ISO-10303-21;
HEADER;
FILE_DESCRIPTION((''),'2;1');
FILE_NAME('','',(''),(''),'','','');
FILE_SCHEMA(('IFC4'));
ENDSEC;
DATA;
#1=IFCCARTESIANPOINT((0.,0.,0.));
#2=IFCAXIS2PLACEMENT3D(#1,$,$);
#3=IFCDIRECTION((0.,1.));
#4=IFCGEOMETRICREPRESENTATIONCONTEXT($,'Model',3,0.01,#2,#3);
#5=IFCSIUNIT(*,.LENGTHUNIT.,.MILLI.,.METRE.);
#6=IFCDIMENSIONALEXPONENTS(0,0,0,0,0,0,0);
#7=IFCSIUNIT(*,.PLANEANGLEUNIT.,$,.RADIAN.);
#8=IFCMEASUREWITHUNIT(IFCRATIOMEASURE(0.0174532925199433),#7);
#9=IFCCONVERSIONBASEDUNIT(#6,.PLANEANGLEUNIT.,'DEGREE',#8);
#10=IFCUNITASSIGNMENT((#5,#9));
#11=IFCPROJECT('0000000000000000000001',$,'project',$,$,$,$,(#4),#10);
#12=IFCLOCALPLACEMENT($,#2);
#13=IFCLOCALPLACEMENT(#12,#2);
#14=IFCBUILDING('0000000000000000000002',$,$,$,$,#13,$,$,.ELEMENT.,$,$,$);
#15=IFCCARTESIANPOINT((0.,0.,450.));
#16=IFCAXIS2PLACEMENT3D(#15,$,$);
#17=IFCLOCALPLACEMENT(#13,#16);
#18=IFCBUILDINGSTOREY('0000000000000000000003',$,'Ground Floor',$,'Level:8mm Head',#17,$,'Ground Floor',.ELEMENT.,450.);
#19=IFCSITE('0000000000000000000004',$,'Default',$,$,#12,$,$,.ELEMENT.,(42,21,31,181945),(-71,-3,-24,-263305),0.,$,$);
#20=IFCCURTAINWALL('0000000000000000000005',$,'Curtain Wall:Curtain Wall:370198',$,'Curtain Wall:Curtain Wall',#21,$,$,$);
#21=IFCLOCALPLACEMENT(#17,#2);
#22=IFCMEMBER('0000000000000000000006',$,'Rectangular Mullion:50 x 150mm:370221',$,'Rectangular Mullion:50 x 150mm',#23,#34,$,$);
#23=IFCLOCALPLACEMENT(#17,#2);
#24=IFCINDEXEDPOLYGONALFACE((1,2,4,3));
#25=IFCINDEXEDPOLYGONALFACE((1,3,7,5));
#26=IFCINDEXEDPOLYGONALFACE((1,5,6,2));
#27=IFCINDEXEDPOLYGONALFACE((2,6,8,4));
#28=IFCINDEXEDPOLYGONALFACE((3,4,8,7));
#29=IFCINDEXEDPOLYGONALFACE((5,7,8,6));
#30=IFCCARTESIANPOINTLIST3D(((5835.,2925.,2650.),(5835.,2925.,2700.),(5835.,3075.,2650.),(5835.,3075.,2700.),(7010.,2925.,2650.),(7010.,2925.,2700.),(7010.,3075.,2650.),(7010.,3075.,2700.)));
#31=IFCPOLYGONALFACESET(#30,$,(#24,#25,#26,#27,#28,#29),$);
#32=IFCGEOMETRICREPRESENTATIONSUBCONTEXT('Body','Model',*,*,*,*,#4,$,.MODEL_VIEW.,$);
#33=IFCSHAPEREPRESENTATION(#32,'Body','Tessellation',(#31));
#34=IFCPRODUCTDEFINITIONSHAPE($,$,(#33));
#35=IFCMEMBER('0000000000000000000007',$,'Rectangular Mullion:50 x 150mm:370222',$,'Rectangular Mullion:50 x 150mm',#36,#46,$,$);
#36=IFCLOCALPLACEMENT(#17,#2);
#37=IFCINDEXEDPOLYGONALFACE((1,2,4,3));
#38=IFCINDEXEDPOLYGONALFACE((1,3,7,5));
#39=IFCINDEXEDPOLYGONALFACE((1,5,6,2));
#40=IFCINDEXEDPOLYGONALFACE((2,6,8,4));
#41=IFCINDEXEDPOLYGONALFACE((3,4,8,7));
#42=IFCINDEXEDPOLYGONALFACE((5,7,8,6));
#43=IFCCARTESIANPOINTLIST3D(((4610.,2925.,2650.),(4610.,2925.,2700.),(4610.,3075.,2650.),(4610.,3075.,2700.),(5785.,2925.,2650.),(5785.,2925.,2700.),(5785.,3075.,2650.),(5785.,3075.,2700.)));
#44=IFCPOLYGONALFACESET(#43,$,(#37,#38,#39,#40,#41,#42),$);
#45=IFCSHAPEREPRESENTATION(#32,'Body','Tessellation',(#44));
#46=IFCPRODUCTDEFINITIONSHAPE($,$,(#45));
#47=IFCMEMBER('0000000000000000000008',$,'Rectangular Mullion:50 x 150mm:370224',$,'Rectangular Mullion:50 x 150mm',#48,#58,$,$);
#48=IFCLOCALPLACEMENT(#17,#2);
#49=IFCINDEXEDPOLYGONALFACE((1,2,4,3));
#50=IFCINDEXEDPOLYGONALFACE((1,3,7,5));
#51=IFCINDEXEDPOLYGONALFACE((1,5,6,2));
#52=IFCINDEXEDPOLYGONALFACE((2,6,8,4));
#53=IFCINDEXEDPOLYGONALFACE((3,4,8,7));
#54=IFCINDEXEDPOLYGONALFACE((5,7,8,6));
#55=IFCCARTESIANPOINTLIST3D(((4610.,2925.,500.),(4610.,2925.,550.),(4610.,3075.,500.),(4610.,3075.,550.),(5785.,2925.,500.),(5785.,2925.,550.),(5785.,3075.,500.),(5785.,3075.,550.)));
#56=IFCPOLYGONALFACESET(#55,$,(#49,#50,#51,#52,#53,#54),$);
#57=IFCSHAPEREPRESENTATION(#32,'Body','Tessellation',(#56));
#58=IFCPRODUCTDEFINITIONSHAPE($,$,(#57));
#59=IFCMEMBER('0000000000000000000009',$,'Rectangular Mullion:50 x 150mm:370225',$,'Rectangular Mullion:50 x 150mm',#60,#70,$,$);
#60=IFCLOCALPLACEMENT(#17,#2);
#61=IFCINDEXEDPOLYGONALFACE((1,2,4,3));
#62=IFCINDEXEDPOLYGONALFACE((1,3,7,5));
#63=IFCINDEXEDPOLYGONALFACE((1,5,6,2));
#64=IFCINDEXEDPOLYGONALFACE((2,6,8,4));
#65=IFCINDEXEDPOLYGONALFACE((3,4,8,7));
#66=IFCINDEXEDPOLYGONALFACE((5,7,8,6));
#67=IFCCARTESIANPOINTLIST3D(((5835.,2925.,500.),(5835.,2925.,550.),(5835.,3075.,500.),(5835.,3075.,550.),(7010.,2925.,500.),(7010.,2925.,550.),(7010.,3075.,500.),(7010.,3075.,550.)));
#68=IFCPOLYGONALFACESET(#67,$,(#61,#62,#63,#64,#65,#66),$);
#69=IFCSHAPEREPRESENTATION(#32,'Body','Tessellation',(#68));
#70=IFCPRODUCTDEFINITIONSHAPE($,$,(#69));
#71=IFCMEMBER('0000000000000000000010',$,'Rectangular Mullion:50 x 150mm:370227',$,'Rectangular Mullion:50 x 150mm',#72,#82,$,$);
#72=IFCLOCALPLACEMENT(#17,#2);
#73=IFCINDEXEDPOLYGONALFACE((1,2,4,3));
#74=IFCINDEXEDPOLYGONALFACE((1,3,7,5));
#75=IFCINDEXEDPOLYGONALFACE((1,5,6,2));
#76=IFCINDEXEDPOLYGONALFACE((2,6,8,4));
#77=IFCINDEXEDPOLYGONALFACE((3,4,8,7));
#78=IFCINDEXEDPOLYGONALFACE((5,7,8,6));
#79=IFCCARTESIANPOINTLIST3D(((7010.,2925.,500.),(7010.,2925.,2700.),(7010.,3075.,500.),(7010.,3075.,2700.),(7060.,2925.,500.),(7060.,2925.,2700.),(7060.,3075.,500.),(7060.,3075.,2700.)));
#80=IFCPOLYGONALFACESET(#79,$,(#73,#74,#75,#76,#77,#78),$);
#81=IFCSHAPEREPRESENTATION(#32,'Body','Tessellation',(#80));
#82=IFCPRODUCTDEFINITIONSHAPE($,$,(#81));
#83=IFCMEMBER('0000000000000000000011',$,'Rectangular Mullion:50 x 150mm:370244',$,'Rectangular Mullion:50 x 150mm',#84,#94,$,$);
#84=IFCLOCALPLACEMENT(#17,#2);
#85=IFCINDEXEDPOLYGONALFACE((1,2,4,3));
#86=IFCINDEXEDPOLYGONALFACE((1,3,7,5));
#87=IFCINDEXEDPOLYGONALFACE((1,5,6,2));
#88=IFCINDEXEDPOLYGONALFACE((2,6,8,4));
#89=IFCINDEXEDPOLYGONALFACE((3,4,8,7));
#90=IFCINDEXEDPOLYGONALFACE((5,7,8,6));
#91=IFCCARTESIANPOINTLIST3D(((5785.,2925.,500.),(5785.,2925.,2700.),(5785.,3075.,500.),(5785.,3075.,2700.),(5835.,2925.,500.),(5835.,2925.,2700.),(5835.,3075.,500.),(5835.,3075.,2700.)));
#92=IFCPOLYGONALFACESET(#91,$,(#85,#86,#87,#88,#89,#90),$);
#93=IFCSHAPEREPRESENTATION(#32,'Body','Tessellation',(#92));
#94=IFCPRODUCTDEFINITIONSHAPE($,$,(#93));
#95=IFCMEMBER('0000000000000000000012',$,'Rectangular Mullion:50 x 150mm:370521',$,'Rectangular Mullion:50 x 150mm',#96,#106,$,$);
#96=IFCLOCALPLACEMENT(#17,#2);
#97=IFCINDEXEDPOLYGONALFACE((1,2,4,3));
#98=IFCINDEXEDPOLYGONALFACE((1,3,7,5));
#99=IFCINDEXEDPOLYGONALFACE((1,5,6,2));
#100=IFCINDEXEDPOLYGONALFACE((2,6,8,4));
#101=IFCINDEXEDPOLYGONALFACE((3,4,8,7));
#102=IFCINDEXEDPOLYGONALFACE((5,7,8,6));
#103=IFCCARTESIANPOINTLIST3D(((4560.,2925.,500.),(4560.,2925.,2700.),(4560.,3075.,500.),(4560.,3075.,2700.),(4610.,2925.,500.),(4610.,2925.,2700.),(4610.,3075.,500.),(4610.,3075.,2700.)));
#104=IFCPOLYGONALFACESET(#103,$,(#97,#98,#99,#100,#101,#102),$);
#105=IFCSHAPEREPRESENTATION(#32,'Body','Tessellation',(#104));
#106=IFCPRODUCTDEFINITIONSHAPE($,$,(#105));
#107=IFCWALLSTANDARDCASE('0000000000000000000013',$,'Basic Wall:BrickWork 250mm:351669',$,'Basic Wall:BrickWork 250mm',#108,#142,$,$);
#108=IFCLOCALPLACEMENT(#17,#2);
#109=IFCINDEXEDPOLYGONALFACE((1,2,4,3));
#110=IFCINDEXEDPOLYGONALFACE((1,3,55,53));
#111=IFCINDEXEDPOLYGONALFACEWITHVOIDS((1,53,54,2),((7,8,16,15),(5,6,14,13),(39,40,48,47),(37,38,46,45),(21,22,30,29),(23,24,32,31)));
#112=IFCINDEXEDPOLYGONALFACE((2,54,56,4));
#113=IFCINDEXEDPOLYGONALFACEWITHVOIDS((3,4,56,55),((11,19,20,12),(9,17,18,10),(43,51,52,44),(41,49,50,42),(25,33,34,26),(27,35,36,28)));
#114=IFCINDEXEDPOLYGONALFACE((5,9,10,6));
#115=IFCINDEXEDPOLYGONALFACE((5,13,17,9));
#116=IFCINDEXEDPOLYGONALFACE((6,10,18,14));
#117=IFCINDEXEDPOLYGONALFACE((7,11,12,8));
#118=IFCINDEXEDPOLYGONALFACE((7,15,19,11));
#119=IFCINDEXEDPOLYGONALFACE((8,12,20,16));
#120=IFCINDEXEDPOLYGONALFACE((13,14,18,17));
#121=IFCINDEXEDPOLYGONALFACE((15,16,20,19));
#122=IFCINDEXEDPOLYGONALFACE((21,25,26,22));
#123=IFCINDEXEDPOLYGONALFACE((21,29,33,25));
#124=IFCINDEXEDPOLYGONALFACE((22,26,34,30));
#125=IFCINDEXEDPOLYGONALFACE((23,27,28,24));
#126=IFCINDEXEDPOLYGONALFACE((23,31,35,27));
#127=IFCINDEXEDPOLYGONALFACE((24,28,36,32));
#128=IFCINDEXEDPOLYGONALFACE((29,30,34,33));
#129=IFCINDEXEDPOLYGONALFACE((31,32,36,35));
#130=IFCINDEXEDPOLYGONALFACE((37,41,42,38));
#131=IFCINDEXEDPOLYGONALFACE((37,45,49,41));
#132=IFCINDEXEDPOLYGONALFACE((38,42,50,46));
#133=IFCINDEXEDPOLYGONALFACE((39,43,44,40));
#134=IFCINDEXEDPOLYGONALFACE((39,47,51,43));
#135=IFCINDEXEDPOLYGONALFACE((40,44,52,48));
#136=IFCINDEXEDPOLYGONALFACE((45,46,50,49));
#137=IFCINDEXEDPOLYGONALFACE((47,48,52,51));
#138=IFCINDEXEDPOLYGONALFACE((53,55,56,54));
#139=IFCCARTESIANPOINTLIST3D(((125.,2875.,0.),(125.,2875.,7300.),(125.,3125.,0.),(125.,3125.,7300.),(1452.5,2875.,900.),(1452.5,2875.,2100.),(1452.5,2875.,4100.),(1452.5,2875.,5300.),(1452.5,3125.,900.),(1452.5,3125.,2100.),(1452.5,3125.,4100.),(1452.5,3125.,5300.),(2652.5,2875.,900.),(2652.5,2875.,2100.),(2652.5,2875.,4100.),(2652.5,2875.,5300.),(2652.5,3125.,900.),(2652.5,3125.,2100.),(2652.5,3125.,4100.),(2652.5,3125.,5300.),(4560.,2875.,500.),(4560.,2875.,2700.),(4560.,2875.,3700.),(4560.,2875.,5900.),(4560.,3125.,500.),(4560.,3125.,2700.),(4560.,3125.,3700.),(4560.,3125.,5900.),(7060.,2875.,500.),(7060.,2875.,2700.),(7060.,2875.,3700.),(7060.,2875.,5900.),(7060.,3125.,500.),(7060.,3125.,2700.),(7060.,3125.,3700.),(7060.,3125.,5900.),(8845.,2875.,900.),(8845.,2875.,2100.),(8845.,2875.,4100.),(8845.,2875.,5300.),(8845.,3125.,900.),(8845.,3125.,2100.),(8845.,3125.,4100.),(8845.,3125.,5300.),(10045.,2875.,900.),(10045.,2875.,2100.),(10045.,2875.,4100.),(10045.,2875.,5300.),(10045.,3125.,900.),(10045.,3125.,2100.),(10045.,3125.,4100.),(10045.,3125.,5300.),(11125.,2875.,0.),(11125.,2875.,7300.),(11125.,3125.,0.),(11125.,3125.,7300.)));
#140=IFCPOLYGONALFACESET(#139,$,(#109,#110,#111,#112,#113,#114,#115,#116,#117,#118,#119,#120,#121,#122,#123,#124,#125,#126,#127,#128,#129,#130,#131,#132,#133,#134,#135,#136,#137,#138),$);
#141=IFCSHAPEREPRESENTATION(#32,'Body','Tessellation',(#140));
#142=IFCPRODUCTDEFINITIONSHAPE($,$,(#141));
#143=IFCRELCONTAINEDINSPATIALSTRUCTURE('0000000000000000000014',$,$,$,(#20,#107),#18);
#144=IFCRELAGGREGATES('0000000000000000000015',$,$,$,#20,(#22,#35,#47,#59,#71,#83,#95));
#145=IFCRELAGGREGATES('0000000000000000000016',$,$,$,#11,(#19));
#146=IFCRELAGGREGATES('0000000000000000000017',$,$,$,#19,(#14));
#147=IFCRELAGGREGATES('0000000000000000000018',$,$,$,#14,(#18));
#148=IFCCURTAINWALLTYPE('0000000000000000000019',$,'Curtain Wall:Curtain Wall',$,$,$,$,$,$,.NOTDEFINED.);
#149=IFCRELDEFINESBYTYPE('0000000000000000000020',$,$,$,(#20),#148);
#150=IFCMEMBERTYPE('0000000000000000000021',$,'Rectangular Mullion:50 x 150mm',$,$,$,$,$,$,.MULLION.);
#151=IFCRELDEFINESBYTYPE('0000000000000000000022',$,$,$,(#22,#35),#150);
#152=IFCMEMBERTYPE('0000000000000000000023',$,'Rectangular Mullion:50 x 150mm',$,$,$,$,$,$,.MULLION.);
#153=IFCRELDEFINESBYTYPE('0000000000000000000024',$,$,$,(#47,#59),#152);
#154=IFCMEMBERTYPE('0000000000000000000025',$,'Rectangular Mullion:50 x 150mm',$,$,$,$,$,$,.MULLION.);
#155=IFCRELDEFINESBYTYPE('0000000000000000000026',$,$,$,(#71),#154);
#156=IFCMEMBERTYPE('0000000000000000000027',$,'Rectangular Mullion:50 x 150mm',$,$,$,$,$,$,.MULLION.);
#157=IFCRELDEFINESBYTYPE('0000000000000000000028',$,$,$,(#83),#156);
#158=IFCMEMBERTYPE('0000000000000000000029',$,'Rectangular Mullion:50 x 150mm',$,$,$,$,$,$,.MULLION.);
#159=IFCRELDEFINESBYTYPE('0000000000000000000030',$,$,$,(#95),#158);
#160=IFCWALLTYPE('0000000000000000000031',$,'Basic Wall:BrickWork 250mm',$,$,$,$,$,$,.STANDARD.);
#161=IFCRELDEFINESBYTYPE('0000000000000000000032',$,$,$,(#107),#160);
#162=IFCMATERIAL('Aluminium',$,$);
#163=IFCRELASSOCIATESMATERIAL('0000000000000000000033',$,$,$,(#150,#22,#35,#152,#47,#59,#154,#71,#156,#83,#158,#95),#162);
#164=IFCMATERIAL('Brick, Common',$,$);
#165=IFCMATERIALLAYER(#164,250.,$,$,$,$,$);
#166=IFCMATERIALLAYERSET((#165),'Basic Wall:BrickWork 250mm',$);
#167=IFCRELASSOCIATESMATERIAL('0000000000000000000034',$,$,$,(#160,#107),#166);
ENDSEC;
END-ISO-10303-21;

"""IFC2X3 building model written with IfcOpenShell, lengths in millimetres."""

from ifc_helpers import new_model, entity, si_unit, converted_unit, direction, frame, frame_2d, origin, origin_2d_with_axis, place, context, subcontext, project, spatial, rectangle, extrude, source, transform, mapped, material, layer, layer_set, layer_usage, type_object, type_shapes, element, aggregate, save


model = new_model("IFC2X3")

# Units and contexts
model_context = context("Model", 3, precision=0.01, world=origin(), true_north=direction((0.0, 1.0)))
body_context = subcontext(model_context, "Body", "Model", "MODEL_VIEW")
ifc_project = project(units=[si_unit("LENGTHUNIT", "METRE", prefix="MILLI"), converted_unit("PLANEANGLEUNIT", "DEGREE", entity("IfcRatioMeasure", 0.0174532925199433), si_unit("PLANEANGLEUNIT", "RADIAN"), dimensions=[0, 0, 0, 0, 0, 0, 0])], contexts=[model_context])

# Site, building, storey
site_placement = place(None, origin())
site = spatial("IfcSite", under=ifc_project, at=site_placement, Name="Default", CompositionType="ELEMENT", RefLatitude=(42, 21, 31, 181945), RefLongitude=(-71, -3, -24, -263305), RefElevation=0.0)
building_placement = place(site_placement, origin())
building = spatial("IfcBuilding", under=site, at=building_placement, CompositionType="ELEMENT")
storey_placement = place(building_placement, frame((0.0, 0.0, 450.0)))
storey = spatial("IfcBuildingStorey", under=building, at=storey_placement, Name="Ground Floor", ObjectType="Level:8mm Head", LongName="Ground Floor", CompositionType="ELEMENT", Elevation=450.0)

# Curtain wall, members
curtain_wall_type = type_object("IfcCurtainWallType", Name="Curtain Wall:Curtain Wall", PredefinedType="NOTDEFINED")
curtain_wall_placement = place(storey_placement, frame((0.0, 0.0, -450.0)))
curtain_wall = element("IfcCurtainWall", 1, at=curtain_wall_placement, inside=storey, type_object=curtain_wall_type, Name="Curtain Wall:Curtain Wall:370198", ObjectType="Curtain Wall:Curtain Wall")
ifc_material_1 = material(Name="Aluminium")
member_type_1 = type_object("IfcMemberType", Name="Rectangular Mullion:50 x 150mm", PredefinedType="MULLION", material=ifc_material_1)
shared_shape_1 = source(origin(), body_context, "Body", "SweptSolid", [
    extrude(rectangle(XDim=150.0, YDim=50.0, at=origin_2d_with_axis()), frame((-25.0, 0.0, -1175.0), z_axis=(0.0, 0.0, 1.0), x_axis=(0.0, -1.0, 0.0)), (0.0, 0.0, 1.0), 1175.0),
])
type_shapes(member_type_1, [shared_shape_1])
member_1_placement = place(storey_placement, frame((7010.0, 3000.0, 2700.0), z_axis=(1.0, 0.0, 0.0), x_axis=(0.0, 0.0, 1.0)))
member_1 = element("IfcMember", 2, at=member_1_placement, type_object=member_type_1, material=ifc_material_1, Name="Rectangular Mullion:50 x 150mm:370221", ObjectType="Rectangular Mullion:50 x 150mm", context=body_context, shape_type="MappedRepresentation", body=[
    mapped(shared_shape_1, transform((0.0, 0.0, 0.0), scale=1.0)),
])
member_2_placement = place(storey_placement, frame((5785.0, 3000.0, 2700.0), z_axis=(1.0, 0.0, 0.0), x_axis=(0.0, 0.0, 1.0)))
member_2 = element("IfcMember", 3, at=member_2_placement, type_object=member_type_1, material=ifc_material_1, Name="Rectangular Mullion:50 x 150mm:370222", ObjectType="Rectangular Mullion:50 x 150mm", context=body_context, shape_type="MappedRepresentation", body=[
    mapped(shared_shape_1, transform((0.0, 0.0, 0.0), scale=1.0)),
])
member_type_2 = type_object("IfcMemberType", Name="Rectangular Mullion:50 x 150mm", PredefinedType="MULLION", material=ifc_material_1)
shared_shape_2 = source(origin(), body_context, "Body", "SweptSolid", [
    extrude(rectangle(XDim=150.0, YDim=50.0, at=origin_2d_with_axis()), frame((-25.0, 0.0, -1175.0), z_axis=(0.0, 0.0, 1.0), x_axis=(0.0, -1.0, 0.0)), (0.0, 0.0, 1.0), 1175.0),
])
type_shapes(member_type_2, [shared_shape_2])
member_3_placement = place(storey_placement, frame((4610.0, 3000.0, 500.0), z_axis=(-1.0, 0.0, 0.0), x_axis=(0.0, 0.0, -1.0)))
member_3 = element("IfcMember", 4, at=member_3_placement, type_object=member_type_2, material=ifc_material_1, Name="Rectangular Mullion:50 x 150mm:370224", ObjectType="Rectangular Mullion:50 x 150mm", context=body_context, shape_type="MappedRepresentation", body=[
    mapped(shared_shape_2, transform((0.0, 0.0, 0.0), scale=1.0)),
])
member_4_placement = place(storey_placement, frame((5835.0, 3000.0, 500.0), z_axis=(-1.0, 0.0, 0.0), x_axis=(0.0, 0.0, -1.0)))
member_4 = element("IfcMember", 5, at=member_4_placement, type_object=member_type_2, material=ifc_material_1, Name="Rectangular Mullion:50 x 150mm:370225", ObjectType="Rectangular Mullion:50 x 150mm", context=body_context, shape_type="MappedRepresentation", body=[
    mapped(shared_shape_2, transform((0.0, 0.0, 0.0), scale=1.0)),
])
member_type_3 = type_object("IfcMemberType", Name="Rectangular Mullion:50 x 150mm", PredefinedType="MULLION", material=ifc_material_1)
shared_shape_3 = source(origin(), body_context, "Body", "SweptSolid", [
    extrude(rectangle(XDim=150.0, YDim=50.0, at=origin_2d_with_axis()), frame((-25.0, 0.0, -2200.0), z_axis=(0.0, 0.0, 1.0), x_axis=(0.0, -1.0, 0.0)), (0.0, 0.0, 1.0), 2200.0),
])
type_shapes(member_type_3, [shared_shape_3])
member_5_placement = place(storey_placement, frame((7060.0, 3000.0, 500.0), z_axis=(0.0, 0.0, -1.0), x_axis=(1.0, 0.0, 0.0)))
member_5 = element("IfcMember", 6, at=member_5_placement, type_object=member_type_3, material=ifc_material_1, Name="Rectangular Mullion:50 x 150mm:370227", ObjectType="Rectangular Mullion:50 x 150mm", context=body_context, shape_type="MappedRepresentation", body=[
    mapped(shared_shape_3, transform((0.0, 0.0, 0.0), scale=1.0)),
])
member_type_4 = type_object("IfcMemberType", Name="Rectangular Mullion:50 x 150mm", PredefinedType="MULLION", material=ifc_material_1)
shared_shape_4 = source(origin(), body_context, "Body", "SweptSolid", [
    extrude(rectangle(XDim=150.0, YDim=50.0, at=origin_2d_with_axis()), frame((0.0, 0.0, -2200.0), z_axis=(0.0, 0.0, 1.0), x_axis=(0.0, -1.0, 0.0)), (0.0, 0.0, 1.0), 2200.0),
])
type_shapes(member_type_4, [shared_shape_4])
member_6_placement = place(storey_placement, frame((5810.0, 3000.0, 500.0), z_axis=(0.0, 0.0, -1.0), x_axis=(1.0, 0.0, 0.0)))
member_6 = element("IfcMember", 7, at=member_6_placement, type_object=member_type_4, material=ifc_material_1, Name="Rectangular Mullion:50 x 150mm:370244", ObjectType="Rectangular Mullion:50 x 150mm", context=body_context, shape_type="MappedRepresentation", body=[
    mapped(shared_shape_4, transform((0.0, 0.0, 0.0), scale=1.0)),
])
member_type_5 = type_object("IfcMemberType", Name="Rectangular Mullion:50 x 150mm", PredefinedType="MULLION", material=ifc_material_1)
shared_shape_5 = source(origin(), body_context, "Body", "SweptSolid", [
    extrude(rectangle(XDim=150.0, YDim=50.0, at=origin_2d_with_axis()), frame((-25.0, 0.0, -2200.0), z_axis=(0.0, 0.0, 1.0), x_axis=(0.0, -1.0, 0.0)), (0.0, 0.0, 1.0), 2200.0),
])
type_shapes(member_type_5, [shared_shape_5])
member_7_placement = place(storey_placement, frame((4560.0, 3000.0, 2700.0), z_axis=(0.0, 0.0, 1.0), x_axis=(-1.0, 0.0, 0.0)))
member_7 = element("IfcMember", 8, at=member_7_placement, type_object=member_type_5, material=ifc_material_1, Name="Rectangular Mullion:50 x 150mm:370521", ObjectType="Rectangular Mullion:50 x 150mm", context=body_context, shape_type="MappedRepresentation", body=[
    mapped(shared_shape_5, transform((0.0, 0.0, 0.0), scale=1.0)),
])

aggregate(curtain_wall, [member_1, member_2, member_3, member_4, member_5, member_6, member_7])

# Wall, openings
ifc_material_2 = material(Name="Brick, Common")
ifc_layer_1 = layer(ifc_material_2, 250.0)
ifc_layer_set_1 = layer_set([ifc_layer_1], Name="Basic Wall:BrickWork 250mm")
ifc_layer_usage_1 = layer_usage(ifc_layer_set_1, "AXIS2", "POSITIVE", -125.0)
wall_type = type_object("IfcWallType", Name="Basic Wall:BrickWork 250mm", PredefinedType="STANDARD", material=ifc_layer_set_1)
wall_placement = place(storey_placement, frame((125.0, 3000.0, 0.0)))
wall = element("IfcWallStandardCase", 9, at=wall_placement, inside=storey, type_object=wall_type, material=ifc_layer_usage_1, Name="Basic Wall:BrickWork 250mm:351669", ObjectType="Basic Wall:BrickWork 250mm", context=body_context, shape_type="SweptSolid", body=[
    extrude(rectangle(XDim=11000.0, YDim=250.0, at=frame_2d((5500.0, 0.0), x_axis=(-1.0, 0.0))), origin(), (0.0, 0.0, 1.0), 7300.0),
])
opening_1_placement = place(wall_placement, origin())
element("IfcOpeningElement", 10, at=opening_1_placement, cuts=wall, ObjectType="Opening", context=body_context, shape_type="SweptSolid", body=[
    extrude(rectangle(XDim=2200.0, YDim=2500.0, at=frame_2d((0.0, 0.0), x_axis=(1.0, 0.0))), frame((5685.0, -277.4, 1600.0), z_axis=(0.0, 1.0, 0.0), x_axis=(0.0, 0.0, 1.0)), (0.0, 0.0, 1.0), 554.8),
])
opening_2_placement = place(wall_placement, origin())
element("IfcOpeningElement", 11, at=opening_2_placement, cuts=wall, ObjectType="Opening", context=body_context, shape_type="SweptSolid", body=[
    extrude(rectangle(XDim=2200.0, YDim=2500.0, at=frame_2d((0.0, 0.0), x_axis=(1.0, 0.0))), frame((5685.0, -277.4, 4800.0), z_axis=(0.0, 1.0, 0.0), x_axis=(0.0, 0.0, 1.0)), (0.0, 0.0, 1.0), 554.8),
])
opening_3_placement = place(wall_placement, frame((1327.5, -125.0, 900.0)))
element("IfcOpeningElement", 12, at=opening_3_placement, cuts=wall, ObjectType="Opening", context=body_context, shape_type="SweptSolid", body=[
    extrude(rectangle(XDim=1200.0, YDim=1200.0, at=frame_2d((600.0, 600.0), x_axis=(-1.0, 0.0))), frame((0.0, 0.0, 0.0), z_axis=(0.0, 1.0, 0.0), x_axis=(0.0, 0.0, 1.0)), (0.0, 0.0, 1.0), 250.0),
])
opening_4_placement = place(wall_placement, frame((8720.0, -125.0, 900.0)))
element("IfcOpeningElement", 13, at=opening_4_placement, cuts=wall, ObjectType="Opening", context=body_context, shape_type="SweptSolid", body=[
    extrude(rectangle(XDim=1200.0, YDim=1200.0, at=frame_2d((600.0, 600.0), x_axis=(-1.0, 0.0))), frame((0.0, 0.0, 0.0), z_axis=(0.0, 1.0, 0.0), x_axis=(0.0, 0.0, 1.0)), (0.0, 0.0, 1.0), 250.0),
])
opening_5_placement = place(wall_placement, frame((1327.5, -125.0, 4100.0)))
element("IfcOpeningElement", 14, at=opening_5_placement, cuts=wall, ObjectType="Opening", context=body_context, shape_type="SweptSolid", body=[
    extrude(rectangle(XDim=1200.0, YDim=1200.0, at=frame_2d((600.0, 600.0), x_axis=(-1.0, 0.0))), frame((0.0, 0.0, 0.0), z_axis=(0.0, 1.0, 0.0), x_axis=(0.0, 0.0, 1.0)), (0.0, 0.0, 1.0), 250.0),
])
opening_6_placement = place(wall_placement, frame((8720.0, -125.0, 4100.0)))
element("IfcOpeningElement", 15, at=opening_6_placement, cuts=wall, ObjectType="Opening", context=body_context, shape_type="SweptSolid", body=[
    extrude(rectangle(XDim=1200.0, YDim=1200.0, at=frame_2d((600.0, 600.0), x_axis=(-1.0, 0.0))), frame((0.0, 0.0, 0.0), z_axis=(0.0, 1.0, 0.0), x_axis=(0.0, 0.0, 1.0)), (0.0, 0.0, 1.0), 250.0),
])

save(model, "model.ifc")
